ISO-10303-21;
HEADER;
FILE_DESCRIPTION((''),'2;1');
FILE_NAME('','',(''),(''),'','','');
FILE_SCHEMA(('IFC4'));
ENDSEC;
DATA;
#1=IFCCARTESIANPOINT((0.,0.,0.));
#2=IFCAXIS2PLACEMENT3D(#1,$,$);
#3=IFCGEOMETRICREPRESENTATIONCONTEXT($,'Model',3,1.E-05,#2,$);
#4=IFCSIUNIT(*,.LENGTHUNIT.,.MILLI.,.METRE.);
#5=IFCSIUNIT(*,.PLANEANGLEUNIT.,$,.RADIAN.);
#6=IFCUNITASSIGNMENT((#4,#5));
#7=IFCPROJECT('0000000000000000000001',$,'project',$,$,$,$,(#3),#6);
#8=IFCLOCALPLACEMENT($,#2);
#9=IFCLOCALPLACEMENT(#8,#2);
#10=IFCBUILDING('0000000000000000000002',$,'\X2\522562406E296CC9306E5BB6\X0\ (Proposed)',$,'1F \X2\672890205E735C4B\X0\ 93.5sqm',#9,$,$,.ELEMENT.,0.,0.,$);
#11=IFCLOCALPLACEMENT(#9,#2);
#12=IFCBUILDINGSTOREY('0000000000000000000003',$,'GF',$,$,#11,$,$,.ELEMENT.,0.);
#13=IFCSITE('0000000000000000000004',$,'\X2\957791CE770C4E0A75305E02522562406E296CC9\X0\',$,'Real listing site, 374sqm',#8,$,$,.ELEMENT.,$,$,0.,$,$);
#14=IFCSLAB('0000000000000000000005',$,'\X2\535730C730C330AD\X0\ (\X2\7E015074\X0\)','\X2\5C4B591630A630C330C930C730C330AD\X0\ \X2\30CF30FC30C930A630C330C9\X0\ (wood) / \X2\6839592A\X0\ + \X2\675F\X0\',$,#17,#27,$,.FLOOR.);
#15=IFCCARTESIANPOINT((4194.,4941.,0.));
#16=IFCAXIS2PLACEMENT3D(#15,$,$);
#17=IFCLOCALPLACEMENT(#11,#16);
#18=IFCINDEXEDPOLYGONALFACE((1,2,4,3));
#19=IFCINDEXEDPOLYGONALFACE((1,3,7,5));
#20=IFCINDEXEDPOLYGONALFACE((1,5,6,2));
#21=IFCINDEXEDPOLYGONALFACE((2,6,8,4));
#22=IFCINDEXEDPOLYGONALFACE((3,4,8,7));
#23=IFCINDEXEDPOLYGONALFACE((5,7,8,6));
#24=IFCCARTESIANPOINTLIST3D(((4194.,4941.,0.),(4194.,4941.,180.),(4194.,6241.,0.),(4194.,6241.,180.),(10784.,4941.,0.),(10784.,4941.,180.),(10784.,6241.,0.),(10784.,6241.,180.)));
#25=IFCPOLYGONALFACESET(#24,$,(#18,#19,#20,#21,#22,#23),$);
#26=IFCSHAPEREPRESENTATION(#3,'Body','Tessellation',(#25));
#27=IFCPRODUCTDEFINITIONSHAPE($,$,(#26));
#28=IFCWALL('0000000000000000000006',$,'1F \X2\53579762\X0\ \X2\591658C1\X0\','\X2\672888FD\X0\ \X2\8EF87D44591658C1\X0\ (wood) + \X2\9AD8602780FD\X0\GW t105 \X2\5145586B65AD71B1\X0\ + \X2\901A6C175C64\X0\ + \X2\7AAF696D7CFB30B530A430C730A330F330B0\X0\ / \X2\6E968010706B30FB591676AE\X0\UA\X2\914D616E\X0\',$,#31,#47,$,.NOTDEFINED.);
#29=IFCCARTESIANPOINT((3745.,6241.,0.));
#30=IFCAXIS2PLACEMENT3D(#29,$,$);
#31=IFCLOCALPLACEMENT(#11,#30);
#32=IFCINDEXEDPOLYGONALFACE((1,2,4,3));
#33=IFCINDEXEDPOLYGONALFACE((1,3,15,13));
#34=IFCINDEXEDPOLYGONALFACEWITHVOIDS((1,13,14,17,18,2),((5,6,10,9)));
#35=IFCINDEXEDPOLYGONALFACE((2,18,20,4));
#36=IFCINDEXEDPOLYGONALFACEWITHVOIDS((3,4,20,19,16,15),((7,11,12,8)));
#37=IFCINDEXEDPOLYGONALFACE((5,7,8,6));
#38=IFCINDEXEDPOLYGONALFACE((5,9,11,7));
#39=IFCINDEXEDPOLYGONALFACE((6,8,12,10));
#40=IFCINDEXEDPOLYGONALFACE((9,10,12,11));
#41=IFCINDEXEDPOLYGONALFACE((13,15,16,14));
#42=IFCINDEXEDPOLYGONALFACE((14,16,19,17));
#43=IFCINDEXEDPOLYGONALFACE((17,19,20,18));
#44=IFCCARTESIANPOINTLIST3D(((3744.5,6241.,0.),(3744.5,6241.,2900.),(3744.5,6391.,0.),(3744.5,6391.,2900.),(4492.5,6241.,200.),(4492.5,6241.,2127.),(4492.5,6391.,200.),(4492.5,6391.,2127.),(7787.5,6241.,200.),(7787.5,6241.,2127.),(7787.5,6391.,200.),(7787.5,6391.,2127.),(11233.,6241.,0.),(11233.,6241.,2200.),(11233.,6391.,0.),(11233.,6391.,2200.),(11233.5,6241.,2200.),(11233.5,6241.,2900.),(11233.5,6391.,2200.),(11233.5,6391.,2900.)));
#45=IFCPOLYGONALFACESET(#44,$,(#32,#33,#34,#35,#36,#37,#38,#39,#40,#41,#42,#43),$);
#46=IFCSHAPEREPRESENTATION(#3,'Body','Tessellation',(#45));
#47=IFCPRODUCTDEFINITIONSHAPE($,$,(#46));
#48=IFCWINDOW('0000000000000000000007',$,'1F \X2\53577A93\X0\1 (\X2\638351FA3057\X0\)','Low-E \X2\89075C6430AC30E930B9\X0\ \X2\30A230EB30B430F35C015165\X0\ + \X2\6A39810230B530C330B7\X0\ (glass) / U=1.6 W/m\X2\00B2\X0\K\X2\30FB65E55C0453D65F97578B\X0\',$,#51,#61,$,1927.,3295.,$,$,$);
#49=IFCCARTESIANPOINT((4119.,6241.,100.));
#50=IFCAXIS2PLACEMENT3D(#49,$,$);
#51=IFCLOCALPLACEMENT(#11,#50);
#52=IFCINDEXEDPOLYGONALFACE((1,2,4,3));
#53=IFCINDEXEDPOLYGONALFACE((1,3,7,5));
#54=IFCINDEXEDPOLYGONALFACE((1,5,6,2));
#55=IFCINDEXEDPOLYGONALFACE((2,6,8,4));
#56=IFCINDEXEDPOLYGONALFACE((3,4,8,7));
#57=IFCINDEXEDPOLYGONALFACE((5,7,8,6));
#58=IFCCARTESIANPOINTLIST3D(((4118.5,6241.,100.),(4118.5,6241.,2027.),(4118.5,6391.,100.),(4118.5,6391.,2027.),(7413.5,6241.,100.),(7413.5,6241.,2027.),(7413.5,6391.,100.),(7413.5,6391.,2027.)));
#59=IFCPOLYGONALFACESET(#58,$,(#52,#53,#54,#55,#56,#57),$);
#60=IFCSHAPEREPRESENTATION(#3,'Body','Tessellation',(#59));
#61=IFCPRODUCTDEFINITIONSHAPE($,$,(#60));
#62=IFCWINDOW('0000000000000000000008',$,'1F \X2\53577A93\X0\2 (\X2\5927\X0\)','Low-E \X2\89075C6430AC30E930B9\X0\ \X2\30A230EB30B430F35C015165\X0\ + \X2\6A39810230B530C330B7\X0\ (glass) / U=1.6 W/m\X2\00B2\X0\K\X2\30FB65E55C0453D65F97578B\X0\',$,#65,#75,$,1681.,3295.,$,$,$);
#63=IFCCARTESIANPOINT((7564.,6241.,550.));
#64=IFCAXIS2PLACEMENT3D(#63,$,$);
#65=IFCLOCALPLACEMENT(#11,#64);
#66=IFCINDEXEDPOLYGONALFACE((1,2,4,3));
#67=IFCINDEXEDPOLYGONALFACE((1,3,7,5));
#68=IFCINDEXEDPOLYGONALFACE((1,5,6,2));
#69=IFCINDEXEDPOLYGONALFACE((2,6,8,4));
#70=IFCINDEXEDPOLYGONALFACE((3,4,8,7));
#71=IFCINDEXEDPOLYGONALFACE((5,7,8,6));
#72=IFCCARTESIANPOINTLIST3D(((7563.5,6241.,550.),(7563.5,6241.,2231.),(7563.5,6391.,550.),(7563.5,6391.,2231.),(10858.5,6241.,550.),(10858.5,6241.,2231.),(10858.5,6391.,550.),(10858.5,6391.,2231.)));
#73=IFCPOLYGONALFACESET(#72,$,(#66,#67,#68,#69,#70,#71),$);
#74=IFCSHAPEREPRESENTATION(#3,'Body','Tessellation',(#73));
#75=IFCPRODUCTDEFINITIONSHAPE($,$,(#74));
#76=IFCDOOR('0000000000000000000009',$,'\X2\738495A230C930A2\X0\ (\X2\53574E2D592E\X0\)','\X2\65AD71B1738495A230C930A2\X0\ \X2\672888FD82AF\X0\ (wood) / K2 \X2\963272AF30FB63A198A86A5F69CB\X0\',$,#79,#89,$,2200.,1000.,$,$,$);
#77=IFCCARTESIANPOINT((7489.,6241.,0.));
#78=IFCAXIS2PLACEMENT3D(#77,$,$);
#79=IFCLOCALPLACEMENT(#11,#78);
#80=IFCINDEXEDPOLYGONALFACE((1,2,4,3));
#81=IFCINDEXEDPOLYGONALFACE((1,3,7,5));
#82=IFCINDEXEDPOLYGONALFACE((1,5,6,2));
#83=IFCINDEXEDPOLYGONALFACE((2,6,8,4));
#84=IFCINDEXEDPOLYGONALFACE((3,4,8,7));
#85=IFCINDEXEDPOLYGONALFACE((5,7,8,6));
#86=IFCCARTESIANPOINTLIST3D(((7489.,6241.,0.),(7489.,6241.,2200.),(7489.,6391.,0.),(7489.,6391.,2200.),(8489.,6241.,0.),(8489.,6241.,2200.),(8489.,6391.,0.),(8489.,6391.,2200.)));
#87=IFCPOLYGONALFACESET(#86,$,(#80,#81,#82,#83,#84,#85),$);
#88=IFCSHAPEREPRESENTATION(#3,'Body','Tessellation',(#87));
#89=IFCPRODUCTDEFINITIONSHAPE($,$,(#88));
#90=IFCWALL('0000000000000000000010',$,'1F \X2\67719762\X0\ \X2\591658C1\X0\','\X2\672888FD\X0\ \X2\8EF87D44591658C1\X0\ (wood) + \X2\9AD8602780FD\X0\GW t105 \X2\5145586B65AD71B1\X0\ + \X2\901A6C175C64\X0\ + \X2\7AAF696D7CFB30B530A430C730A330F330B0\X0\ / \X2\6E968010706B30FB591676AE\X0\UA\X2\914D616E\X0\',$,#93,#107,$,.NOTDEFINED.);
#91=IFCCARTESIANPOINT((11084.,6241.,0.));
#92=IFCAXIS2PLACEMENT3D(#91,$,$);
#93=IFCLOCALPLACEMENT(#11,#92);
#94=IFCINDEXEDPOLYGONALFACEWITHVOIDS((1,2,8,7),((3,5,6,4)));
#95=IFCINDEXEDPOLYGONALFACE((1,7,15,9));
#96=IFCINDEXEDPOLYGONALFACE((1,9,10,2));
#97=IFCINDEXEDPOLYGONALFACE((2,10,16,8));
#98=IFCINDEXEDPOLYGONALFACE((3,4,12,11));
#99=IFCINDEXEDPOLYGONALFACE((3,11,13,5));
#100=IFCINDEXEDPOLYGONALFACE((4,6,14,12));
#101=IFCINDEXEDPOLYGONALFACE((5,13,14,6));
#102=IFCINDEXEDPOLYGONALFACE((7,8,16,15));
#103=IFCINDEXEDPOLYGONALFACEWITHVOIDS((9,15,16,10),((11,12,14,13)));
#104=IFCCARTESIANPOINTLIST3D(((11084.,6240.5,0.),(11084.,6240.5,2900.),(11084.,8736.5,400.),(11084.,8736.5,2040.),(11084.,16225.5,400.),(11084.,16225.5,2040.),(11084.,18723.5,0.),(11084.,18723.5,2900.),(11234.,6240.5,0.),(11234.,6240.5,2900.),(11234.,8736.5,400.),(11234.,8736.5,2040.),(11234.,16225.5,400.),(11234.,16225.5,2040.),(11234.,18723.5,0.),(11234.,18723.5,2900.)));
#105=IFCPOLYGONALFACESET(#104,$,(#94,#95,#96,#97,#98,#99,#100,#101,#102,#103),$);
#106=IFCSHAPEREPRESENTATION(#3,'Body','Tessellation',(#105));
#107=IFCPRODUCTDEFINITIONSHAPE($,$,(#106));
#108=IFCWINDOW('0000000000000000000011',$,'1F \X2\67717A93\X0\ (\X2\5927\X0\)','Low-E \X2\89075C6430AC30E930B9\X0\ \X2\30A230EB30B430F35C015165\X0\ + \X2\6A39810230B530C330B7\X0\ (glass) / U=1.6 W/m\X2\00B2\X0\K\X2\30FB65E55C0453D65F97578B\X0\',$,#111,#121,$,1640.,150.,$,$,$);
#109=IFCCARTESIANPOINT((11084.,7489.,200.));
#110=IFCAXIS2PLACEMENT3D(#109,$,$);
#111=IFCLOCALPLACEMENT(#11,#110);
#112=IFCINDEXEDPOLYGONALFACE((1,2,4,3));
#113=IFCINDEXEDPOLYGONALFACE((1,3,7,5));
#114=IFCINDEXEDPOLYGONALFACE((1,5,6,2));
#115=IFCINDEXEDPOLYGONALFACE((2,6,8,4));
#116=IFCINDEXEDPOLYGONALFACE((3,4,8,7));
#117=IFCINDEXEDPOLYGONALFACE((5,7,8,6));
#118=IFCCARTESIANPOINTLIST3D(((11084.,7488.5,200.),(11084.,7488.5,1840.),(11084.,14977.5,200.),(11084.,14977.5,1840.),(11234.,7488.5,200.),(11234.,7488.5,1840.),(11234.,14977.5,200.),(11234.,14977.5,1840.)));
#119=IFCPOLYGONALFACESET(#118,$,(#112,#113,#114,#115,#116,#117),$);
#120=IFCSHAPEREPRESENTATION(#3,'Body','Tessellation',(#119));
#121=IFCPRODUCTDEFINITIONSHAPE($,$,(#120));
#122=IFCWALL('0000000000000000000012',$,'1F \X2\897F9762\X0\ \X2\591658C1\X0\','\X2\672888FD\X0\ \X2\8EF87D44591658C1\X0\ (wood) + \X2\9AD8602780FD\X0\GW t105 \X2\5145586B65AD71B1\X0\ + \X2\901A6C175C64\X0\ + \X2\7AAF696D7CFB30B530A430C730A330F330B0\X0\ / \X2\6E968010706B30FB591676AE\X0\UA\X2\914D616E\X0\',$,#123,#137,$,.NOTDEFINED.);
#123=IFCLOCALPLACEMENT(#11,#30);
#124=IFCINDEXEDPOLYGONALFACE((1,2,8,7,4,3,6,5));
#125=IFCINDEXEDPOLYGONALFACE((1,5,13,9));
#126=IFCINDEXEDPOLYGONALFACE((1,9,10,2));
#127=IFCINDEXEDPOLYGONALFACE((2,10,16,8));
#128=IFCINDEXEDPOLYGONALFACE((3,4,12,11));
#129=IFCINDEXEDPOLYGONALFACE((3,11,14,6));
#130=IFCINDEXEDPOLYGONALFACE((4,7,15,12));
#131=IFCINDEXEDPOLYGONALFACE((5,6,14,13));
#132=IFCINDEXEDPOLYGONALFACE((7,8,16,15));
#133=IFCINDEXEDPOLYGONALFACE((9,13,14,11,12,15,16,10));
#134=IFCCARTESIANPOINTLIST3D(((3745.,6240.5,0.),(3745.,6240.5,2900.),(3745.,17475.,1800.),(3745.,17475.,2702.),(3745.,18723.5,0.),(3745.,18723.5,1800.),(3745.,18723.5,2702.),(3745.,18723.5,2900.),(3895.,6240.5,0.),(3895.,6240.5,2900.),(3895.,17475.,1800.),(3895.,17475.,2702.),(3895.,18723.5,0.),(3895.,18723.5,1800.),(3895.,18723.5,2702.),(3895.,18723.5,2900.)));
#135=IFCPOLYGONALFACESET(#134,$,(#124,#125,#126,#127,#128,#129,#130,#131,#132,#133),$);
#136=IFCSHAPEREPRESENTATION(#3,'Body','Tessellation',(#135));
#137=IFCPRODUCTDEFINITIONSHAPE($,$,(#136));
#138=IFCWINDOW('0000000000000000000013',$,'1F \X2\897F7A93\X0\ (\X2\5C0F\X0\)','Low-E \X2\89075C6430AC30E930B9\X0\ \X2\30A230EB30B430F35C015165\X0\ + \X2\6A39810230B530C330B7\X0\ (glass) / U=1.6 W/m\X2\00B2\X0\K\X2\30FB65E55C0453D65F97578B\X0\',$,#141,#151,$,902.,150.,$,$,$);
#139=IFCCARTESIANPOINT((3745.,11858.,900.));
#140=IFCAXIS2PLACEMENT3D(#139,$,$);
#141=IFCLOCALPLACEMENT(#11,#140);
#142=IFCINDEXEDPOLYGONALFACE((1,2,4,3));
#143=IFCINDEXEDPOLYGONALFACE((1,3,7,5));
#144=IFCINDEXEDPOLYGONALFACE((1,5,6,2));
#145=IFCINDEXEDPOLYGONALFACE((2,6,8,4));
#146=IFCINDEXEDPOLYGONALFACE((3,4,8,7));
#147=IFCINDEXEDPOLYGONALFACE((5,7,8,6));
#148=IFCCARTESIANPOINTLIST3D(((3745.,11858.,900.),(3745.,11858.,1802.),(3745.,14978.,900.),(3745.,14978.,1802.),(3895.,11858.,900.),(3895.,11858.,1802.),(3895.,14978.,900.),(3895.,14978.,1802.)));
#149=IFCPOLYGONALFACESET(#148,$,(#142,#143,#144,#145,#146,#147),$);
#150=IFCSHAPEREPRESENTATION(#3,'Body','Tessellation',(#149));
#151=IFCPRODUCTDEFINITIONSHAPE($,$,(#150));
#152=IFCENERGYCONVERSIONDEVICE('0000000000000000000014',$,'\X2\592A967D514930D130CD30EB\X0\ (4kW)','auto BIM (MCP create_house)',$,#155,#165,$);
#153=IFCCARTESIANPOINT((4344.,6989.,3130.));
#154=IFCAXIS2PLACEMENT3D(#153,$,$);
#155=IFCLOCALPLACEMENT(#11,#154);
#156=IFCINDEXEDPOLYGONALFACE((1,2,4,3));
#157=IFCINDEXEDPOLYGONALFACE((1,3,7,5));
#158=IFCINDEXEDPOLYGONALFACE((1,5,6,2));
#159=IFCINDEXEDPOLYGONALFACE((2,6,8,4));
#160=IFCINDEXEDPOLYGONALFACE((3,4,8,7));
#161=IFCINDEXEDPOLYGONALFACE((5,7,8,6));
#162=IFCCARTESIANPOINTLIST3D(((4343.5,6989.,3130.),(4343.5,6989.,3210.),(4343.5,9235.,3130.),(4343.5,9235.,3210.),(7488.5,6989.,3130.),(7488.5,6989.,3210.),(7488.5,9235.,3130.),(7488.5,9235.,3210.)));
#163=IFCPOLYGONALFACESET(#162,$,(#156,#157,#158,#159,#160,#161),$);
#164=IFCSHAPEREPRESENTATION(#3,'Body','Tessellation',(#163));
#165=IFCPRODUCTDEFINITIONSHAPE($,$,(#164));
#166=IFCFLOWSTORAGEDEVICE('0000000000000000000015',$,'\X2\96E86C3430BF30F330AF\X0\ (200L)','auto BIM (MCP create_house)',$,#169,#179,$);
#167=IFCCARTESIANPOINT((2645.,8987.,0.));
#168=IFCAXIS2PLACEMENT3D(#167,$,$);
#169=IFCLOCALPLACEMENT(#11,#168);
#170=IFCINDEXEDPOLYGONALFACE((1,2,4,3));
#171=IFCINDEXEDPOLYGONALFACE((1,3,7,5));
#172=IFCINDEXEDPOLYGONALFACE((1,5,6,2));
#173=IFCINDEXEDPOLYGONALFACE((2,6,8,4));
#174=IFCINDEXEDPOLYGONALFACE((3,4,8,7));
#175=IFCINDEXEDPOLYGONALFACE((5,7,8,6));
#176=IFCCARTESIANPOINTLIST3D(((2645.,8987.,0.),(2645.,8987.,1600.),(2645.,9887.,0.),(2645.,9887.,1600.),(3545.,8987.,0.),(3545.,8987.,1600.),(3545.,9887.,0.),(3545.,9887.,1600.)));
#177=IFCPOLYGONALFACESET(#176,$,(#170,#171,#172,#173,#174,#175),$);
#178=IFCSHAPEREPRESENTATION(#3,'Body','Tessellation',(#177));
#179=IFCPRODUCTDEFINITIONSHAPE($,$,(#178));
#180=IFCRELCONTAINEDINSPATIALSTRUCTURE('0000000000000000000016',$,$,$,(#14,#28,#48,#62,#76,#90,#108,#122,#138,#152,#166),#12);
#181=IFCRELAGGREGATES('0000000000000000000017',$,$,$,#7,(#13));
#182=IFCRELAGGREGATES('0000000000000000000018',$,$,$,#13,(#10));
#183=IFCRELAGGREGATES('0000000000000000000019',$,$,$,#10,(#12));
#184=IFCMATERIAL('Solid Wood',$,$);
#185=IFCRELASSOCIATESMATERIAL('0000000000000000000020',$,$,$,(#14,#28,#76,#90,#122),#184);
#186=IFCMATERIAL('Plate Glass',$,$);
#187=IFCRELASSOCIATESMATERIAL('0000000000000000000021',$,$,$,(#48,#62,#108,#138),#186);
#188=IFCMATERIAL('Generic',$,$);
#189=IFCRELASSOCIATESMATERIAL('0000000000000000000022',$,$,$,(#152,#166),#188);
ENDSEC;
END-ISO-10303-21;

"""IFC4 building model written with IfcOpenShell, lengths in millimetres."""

from ifc_helpers import new_model, si_unit, frame, frame_2d, origin, place, context, project, spatial, rectangle, extrude, material, element, fill, save


model = new_model("IFC4")

# Units and contexts
model_context = context("Model", 3, precision=1e-05, world=origin())
ifc_project = project(units=[si_unit("LENGTHUNIT", "METRE", prefix="MILLI"), si_unit("PLANEANGLEUNIT", "RADIAN")], contexts=[model_context])

# Site, building, storey
site_placement = place(None, origin())
site = spatial("IfcSite", under=ifc_project, at=site_placement, Name="長野県上田市別所温泉", ObjectType="Real listing site, 374sqm", CompositionType="ELEMENT", RefElevation=0.0)
building_placement = place(site_placement, origin())
building = spatial("IfcBuilding", under=site, at=building_placement, Name="別所温泉の家 (Proposed)", ObjectType="1F 木造平屋 93.5sqm", CompositionType="ELEMENT", ElevationOfRefHeight=0.0, ElevationOfTerrain=0.0)
storey_placement = place(building_placement, origin())
storey = spatial("IfcBuildingStorey", under=building, at=storey_placement, Name="GF", CompositionType="ELEMENT", Elevation=0.0)

# Slab
ifc_material_1 = material(Name="Solid Wood")
slab_1_placement = place(storey_placement, frame((4194.0, 4941.0, 0.0)))
element("IfcSlab", 1, at=slab_1_placement, inside=storey, material=ifc_material_1, Name="南デッキ (縁側)", Description="屋外ウッドデッキ ハードウッド (wood) / 根太 + 束", PredefinedType="FLOOR", context=model_context, shape_type="SweptSolid", body=[
    extrude(rectangle(XDim=6590.0, YDim=1300.0, at=frame_2d((3295.0, 650.0))), frame((4194.0, 4941.0, 0.0)), (0.0, 0.0, 1.0), 180.0),
])

# Wall, openings, windows, door
wall_1_placement = place(storey_placement, frame((3745.0, 6241.0, 0.0)))
wall_1 = element("IfcWall", 2, at=wall_1_placement, inside=storey, material=ifc_material_1, Name="1F 南面 外壁", Description="木製 軸組外壁 (wood) + 高性能GW t105 充填断熱 + 通気層 + 窯業系サイディング / 準耐火・外皮UA配慮", PredefinedType="NOTDEFINED", context=model_context, shape_type="SweptSolid", body=[
    extrude(rectangle(XDim=7489.0, YDim=150.0, at=frame_2d((3744.0, 75.0))), frame((3745.0, 6241.0, 0.0)), (0.0, 0.0, 1.0), 2900.0),
])
opening_1_placement = place(storey_placement, frame((4119.0, 6241.0, 100.0)))
opening_1 = element("IfcOpeningElement", 3, at=opening_1_placement, cuts=wall_1, PredefinedType="NOTDEFINED", context=model_context, shape_type="SweptSolid", body=[
    extrude(rectangle(XDim=3295.0, YDim=150.0, at=frame_2d((1647.0, 75.0))), frame((4119.0, 6241.0, 100.0)), (0.0, 0.0, 1.0), 1927.0),
])
opening_2_placement = place(storey_placement, frame((7564.0, 6241.0, 550.0)))
opening_2 = element("IfcOpeningElement", 4, at=opening_2_placement, cuts=wall_1, PredefinedType="NOTDEFINED", context=model_context, shape_type="SweptSolid", body=[
    extrude(rectangle(XDim=3295.0, YDim=150.0, at=frame_2d((1647.0, 75.0))), frame((7564.0, 6241.0, 550.0)), (0.0, 0.0, 1.0), 1681.0),
])
opening_3_placement = place(storey_placement, frame((7489.0, 6241.0, 0.0)))
opening_3 = element("IfcOpeningElement", 5, at=opening_3_placement, cuts=wall_1, PredefinedType="NOTDEFINED", context=model_context, shape_type="SweptSolid", body=[
    extrude(rectangle(XDim=1000.0, YDim=150.0, at=frame_2d((500.0, 75.0))), frame((7489.0, 6241.0, 0.0)), (0.0, 0.0, 1.0), 2200.0),
])
ifc_material_2 = material(Name="Plate Glass")
window_1_placement = place(storey_placement, frame((4119.0, 6241.0, 100.0)))
window_1 = element("IfcWindow", 6, at=window_1_placement, inside=storey, material=ifc_material_2, Name="1F 南窓1 (掃出し)", Description="Low-E 複層ガラス アルゴン封入 + 樹脂サッシ (glass) / U=1.6 W/m²K・日射取得型", OverallHeight=1927.0, OverallWidth=3295.0, context=model_context, shape_type="SweptSolid", body=[
    extrude(rectangle(XDim=3295.0, YDim=150.0, at=frame_2d((1647.0, 75.0))), frame((4119.0, 6241.0, 100.0)), (0.0, 0.0, 1.0), 1927.0),
])
fill(opening_1, window_1)
window_2_placement = place(storey_placement, frame((7564.0, 6241.0, 550.0)))
window_2 = element("IfcWindow", 7, at=window_2_placement, inside=storey, material=ifc_material_2, Name="1F 南窓2 (大)", Description="Low-E 複層ガラス アルゴン封入 + 樹脂サッシ (glass) / U=1.6 W/m²K・日射取得型", OverallHeight=1681.0, OverallWidth=3295.0, context=model_context, shape_type="SweptSolid", body=[
    extrude(rectangle(XDim=3295.0, YDim=150.0, at=frame_2d((1647.0, 75.0))), frame((7564.0, 6241.0, 550.0)), (0.0, 0.0, 1.0), 1681.0),
])
fill(opening_2, window_2)
door_placement = place(storey_placement, frame((7489.0, 6241.0, 0.0)))
door = element("IfcDoor", 8, at=door_placement, inside=storey, material=ifc_material_1, Name="玄関ドア (南中央)", Description="断熱玄関ドア 木製芯 (wood) / K2 防犯・採風機構", OverallHeight=2200.0, OverallWidth=1000.0, context=model_context, shape_type="SweptSolid", body=[
    extrude(rectangle(XDim=1000.0, YDim=150.0, at=frame_2d((500.0, 75.0))), frame((7489.0, 6241.0, 0.0)), (0.0, 0.0, 1.0), 2200.0),
])
fill(opening_3, door)

# Walls, openings, windows
wall_2_placement = place(storey_placement, frame((11084.0, 6241.0, 0.0)))
wall_2 = element("IfcWall", 9, at=wall_2_placement, inside=storey, material=ifc_material_1, Name="1F 東面 外壁", Description="木製 軸組外壁 (wood) + 高性能GW t105 充填断熱 + 通気層 + 窯業系サイディング / 準耐火・外皮UA配慮", PredefinedType="NOTDEFINED", context=model_context, shape_type="SweptSolid", body=[
    extrude(rectangle(XDim=150.0, YDim=12483.0, at=frame_2d((75.0, 6241.0))), frame((11084.0, 6241.0, 0.0)), (0.0, 0.0, 1.0), 2900.0),
])
opening_4_placement = place(storey_placement, frame((11084.0, 7489.0, 200.0)))
opening_4 = element("IfcOpeningElement", 10, at=opening_4_placement, cuts=wall_2, PredefinedType="NOTDEFINED", context=model_context, shape_type="SweptSolid", body=[
    extrude(rectangle(XDim=150.0, YDim=7489.0, at=frame_2d((75.0, 3744.0))), frame((11084.0, 7489.0, 200.0)), (0.0, 0.0, 1.0), 1640.0),
])
window_3_placement = place(storey_placement, frame((11084.0, 7489.0, 200.0)))
window_3 = element("IfcWindow", 11, at=window_3_placement, inside=storey, material=ifc_material_2, Name="1F 東窓 (大)", Description="Low-E 複層ガラス アルゴン封入 + 樹脂サッシ (glass) / U=1.6 W/m²K・日射取得型", OverallHeight=1640.0, OverallWidth=150.0, context=model_context, shape_type="SweptSolid", body=[
    extrude(rectangle(XDim=150.0, YDim=7489.0, at=frame_2d((75.0, 3744.0))), frame((11084.0, 7489.0, 200.0)), (0.0, 0.0, 1.0), 1640.0),
])
fill(opening_4, window_3)
wall_3_placement = place(storey_placement, frame((3745.0, 6241.0, 0.0)))
wall_3 = element("IfcWall", 12, at=wall_3_placement, inside=storey, material=ifc_material_1, Name="1F 西面 外壁", Description="木製 軸組外壁 (wood) + 高性能GW t105 充填断熱 + 通気層 + 窯業系サイディング / 準耐火・外皮UA配慮", PredefinedType="NOTDEFINED", context=model_context, shape_type="SweptSolid", body=[
    extrude(rectangle(XDim=150.0, YDim=12483.0, at=frame_2d((75.0, 6241.0))), frame((3745.0, 6241.0, 0.0)), (0.0, 0.0, 1.0), 2900.0),
])
opening_5_placement = place(storey_placement, frame((3745.0, 11858.0, 900.0)))
opening_5 = element("IfcOpeningElement", 13, at=opening_5_placement, cuts=wall_3, PredefinedType="NOTDEFINED", context=model_context, shape_type="SweptSolid", body=[
    extrude(rectangle(XDim=150.0, YDim=3120.0, at=frame_2d((75.0, 1560.0))), frame((3745.0, 11858.0, 900.0)), (0.0, 0.0, 1.0), 902.0),
])
window_4_placement = place(storey_placement, frame((3745.0, 11858.0, 900.0)))
window_4 = element("IfcWindow", 14, at=window_4_placement, inside=storey, material=ifc_material_2, Name="1F 西窓 (小)", Description="Low-E 複層ガラス アルゴン封入 + 樹脂サッシ (glass) / U=1.6 W/m²K・日射取得型", OverallHeight=902.0, OverallWidth=150.0, context=model_context, shape_type="SweptSolid", body=[
    extrude(rectangle(XDim=150.0, YDim=3120.0, at=frame_2d((75.0, 1560.0))), frame((3745.0, 11858.0, 900.0)), (0.0, 0.0, 1.0), 902.0),
])
fill(opening_5, window_4)

# Shared definitions
ifc_material_3 = material(Name="Generic")

# Energy conversion device
energy_conversion_device_placement = place(storey_placement, frame((4344.0, 6989.0, 3130.0)))
element("IfcEnergyConversionDevice", 15, at=energy_conversion_device_placement, inside=storey, material=ifc_material_3, Name="太陽光パネル (4kW)", Description="auto BIM (MCP create_house)", context=model_context, shape_type="SweptSolid", body=[
    extrude(rectangle(XDim=3145.0, YDim=2246.0, at=frame_2d((1572.0, 1123.0))), frame((4344.0, 6989.0, 3130.0)), (0.0, 0.0, 1.0), 80.0),
])

# Flow storage device
flow_storage_device_placement = place(storey_placement, frame((2645.0, 8987.0, 0.0)))
element("IfcFlowStorageDevice", 16, at=flow_storage_device_placement, inside=storey, material=ifc_material_3, Name="雨水タンク (200L)", Description="auto BIM (MCP create_house)", context=model_context, shape_type="SweptSolid", body=[
    extrude(rectangle(XDim=900.0, YDim=900.0, at=frame_2d((450.0, 450.0))), frame((2645.0, 8987.0, 0.0)), (0.0, 0.0, 1.0), 1600.0),
])

save(model, "model.ifc")
